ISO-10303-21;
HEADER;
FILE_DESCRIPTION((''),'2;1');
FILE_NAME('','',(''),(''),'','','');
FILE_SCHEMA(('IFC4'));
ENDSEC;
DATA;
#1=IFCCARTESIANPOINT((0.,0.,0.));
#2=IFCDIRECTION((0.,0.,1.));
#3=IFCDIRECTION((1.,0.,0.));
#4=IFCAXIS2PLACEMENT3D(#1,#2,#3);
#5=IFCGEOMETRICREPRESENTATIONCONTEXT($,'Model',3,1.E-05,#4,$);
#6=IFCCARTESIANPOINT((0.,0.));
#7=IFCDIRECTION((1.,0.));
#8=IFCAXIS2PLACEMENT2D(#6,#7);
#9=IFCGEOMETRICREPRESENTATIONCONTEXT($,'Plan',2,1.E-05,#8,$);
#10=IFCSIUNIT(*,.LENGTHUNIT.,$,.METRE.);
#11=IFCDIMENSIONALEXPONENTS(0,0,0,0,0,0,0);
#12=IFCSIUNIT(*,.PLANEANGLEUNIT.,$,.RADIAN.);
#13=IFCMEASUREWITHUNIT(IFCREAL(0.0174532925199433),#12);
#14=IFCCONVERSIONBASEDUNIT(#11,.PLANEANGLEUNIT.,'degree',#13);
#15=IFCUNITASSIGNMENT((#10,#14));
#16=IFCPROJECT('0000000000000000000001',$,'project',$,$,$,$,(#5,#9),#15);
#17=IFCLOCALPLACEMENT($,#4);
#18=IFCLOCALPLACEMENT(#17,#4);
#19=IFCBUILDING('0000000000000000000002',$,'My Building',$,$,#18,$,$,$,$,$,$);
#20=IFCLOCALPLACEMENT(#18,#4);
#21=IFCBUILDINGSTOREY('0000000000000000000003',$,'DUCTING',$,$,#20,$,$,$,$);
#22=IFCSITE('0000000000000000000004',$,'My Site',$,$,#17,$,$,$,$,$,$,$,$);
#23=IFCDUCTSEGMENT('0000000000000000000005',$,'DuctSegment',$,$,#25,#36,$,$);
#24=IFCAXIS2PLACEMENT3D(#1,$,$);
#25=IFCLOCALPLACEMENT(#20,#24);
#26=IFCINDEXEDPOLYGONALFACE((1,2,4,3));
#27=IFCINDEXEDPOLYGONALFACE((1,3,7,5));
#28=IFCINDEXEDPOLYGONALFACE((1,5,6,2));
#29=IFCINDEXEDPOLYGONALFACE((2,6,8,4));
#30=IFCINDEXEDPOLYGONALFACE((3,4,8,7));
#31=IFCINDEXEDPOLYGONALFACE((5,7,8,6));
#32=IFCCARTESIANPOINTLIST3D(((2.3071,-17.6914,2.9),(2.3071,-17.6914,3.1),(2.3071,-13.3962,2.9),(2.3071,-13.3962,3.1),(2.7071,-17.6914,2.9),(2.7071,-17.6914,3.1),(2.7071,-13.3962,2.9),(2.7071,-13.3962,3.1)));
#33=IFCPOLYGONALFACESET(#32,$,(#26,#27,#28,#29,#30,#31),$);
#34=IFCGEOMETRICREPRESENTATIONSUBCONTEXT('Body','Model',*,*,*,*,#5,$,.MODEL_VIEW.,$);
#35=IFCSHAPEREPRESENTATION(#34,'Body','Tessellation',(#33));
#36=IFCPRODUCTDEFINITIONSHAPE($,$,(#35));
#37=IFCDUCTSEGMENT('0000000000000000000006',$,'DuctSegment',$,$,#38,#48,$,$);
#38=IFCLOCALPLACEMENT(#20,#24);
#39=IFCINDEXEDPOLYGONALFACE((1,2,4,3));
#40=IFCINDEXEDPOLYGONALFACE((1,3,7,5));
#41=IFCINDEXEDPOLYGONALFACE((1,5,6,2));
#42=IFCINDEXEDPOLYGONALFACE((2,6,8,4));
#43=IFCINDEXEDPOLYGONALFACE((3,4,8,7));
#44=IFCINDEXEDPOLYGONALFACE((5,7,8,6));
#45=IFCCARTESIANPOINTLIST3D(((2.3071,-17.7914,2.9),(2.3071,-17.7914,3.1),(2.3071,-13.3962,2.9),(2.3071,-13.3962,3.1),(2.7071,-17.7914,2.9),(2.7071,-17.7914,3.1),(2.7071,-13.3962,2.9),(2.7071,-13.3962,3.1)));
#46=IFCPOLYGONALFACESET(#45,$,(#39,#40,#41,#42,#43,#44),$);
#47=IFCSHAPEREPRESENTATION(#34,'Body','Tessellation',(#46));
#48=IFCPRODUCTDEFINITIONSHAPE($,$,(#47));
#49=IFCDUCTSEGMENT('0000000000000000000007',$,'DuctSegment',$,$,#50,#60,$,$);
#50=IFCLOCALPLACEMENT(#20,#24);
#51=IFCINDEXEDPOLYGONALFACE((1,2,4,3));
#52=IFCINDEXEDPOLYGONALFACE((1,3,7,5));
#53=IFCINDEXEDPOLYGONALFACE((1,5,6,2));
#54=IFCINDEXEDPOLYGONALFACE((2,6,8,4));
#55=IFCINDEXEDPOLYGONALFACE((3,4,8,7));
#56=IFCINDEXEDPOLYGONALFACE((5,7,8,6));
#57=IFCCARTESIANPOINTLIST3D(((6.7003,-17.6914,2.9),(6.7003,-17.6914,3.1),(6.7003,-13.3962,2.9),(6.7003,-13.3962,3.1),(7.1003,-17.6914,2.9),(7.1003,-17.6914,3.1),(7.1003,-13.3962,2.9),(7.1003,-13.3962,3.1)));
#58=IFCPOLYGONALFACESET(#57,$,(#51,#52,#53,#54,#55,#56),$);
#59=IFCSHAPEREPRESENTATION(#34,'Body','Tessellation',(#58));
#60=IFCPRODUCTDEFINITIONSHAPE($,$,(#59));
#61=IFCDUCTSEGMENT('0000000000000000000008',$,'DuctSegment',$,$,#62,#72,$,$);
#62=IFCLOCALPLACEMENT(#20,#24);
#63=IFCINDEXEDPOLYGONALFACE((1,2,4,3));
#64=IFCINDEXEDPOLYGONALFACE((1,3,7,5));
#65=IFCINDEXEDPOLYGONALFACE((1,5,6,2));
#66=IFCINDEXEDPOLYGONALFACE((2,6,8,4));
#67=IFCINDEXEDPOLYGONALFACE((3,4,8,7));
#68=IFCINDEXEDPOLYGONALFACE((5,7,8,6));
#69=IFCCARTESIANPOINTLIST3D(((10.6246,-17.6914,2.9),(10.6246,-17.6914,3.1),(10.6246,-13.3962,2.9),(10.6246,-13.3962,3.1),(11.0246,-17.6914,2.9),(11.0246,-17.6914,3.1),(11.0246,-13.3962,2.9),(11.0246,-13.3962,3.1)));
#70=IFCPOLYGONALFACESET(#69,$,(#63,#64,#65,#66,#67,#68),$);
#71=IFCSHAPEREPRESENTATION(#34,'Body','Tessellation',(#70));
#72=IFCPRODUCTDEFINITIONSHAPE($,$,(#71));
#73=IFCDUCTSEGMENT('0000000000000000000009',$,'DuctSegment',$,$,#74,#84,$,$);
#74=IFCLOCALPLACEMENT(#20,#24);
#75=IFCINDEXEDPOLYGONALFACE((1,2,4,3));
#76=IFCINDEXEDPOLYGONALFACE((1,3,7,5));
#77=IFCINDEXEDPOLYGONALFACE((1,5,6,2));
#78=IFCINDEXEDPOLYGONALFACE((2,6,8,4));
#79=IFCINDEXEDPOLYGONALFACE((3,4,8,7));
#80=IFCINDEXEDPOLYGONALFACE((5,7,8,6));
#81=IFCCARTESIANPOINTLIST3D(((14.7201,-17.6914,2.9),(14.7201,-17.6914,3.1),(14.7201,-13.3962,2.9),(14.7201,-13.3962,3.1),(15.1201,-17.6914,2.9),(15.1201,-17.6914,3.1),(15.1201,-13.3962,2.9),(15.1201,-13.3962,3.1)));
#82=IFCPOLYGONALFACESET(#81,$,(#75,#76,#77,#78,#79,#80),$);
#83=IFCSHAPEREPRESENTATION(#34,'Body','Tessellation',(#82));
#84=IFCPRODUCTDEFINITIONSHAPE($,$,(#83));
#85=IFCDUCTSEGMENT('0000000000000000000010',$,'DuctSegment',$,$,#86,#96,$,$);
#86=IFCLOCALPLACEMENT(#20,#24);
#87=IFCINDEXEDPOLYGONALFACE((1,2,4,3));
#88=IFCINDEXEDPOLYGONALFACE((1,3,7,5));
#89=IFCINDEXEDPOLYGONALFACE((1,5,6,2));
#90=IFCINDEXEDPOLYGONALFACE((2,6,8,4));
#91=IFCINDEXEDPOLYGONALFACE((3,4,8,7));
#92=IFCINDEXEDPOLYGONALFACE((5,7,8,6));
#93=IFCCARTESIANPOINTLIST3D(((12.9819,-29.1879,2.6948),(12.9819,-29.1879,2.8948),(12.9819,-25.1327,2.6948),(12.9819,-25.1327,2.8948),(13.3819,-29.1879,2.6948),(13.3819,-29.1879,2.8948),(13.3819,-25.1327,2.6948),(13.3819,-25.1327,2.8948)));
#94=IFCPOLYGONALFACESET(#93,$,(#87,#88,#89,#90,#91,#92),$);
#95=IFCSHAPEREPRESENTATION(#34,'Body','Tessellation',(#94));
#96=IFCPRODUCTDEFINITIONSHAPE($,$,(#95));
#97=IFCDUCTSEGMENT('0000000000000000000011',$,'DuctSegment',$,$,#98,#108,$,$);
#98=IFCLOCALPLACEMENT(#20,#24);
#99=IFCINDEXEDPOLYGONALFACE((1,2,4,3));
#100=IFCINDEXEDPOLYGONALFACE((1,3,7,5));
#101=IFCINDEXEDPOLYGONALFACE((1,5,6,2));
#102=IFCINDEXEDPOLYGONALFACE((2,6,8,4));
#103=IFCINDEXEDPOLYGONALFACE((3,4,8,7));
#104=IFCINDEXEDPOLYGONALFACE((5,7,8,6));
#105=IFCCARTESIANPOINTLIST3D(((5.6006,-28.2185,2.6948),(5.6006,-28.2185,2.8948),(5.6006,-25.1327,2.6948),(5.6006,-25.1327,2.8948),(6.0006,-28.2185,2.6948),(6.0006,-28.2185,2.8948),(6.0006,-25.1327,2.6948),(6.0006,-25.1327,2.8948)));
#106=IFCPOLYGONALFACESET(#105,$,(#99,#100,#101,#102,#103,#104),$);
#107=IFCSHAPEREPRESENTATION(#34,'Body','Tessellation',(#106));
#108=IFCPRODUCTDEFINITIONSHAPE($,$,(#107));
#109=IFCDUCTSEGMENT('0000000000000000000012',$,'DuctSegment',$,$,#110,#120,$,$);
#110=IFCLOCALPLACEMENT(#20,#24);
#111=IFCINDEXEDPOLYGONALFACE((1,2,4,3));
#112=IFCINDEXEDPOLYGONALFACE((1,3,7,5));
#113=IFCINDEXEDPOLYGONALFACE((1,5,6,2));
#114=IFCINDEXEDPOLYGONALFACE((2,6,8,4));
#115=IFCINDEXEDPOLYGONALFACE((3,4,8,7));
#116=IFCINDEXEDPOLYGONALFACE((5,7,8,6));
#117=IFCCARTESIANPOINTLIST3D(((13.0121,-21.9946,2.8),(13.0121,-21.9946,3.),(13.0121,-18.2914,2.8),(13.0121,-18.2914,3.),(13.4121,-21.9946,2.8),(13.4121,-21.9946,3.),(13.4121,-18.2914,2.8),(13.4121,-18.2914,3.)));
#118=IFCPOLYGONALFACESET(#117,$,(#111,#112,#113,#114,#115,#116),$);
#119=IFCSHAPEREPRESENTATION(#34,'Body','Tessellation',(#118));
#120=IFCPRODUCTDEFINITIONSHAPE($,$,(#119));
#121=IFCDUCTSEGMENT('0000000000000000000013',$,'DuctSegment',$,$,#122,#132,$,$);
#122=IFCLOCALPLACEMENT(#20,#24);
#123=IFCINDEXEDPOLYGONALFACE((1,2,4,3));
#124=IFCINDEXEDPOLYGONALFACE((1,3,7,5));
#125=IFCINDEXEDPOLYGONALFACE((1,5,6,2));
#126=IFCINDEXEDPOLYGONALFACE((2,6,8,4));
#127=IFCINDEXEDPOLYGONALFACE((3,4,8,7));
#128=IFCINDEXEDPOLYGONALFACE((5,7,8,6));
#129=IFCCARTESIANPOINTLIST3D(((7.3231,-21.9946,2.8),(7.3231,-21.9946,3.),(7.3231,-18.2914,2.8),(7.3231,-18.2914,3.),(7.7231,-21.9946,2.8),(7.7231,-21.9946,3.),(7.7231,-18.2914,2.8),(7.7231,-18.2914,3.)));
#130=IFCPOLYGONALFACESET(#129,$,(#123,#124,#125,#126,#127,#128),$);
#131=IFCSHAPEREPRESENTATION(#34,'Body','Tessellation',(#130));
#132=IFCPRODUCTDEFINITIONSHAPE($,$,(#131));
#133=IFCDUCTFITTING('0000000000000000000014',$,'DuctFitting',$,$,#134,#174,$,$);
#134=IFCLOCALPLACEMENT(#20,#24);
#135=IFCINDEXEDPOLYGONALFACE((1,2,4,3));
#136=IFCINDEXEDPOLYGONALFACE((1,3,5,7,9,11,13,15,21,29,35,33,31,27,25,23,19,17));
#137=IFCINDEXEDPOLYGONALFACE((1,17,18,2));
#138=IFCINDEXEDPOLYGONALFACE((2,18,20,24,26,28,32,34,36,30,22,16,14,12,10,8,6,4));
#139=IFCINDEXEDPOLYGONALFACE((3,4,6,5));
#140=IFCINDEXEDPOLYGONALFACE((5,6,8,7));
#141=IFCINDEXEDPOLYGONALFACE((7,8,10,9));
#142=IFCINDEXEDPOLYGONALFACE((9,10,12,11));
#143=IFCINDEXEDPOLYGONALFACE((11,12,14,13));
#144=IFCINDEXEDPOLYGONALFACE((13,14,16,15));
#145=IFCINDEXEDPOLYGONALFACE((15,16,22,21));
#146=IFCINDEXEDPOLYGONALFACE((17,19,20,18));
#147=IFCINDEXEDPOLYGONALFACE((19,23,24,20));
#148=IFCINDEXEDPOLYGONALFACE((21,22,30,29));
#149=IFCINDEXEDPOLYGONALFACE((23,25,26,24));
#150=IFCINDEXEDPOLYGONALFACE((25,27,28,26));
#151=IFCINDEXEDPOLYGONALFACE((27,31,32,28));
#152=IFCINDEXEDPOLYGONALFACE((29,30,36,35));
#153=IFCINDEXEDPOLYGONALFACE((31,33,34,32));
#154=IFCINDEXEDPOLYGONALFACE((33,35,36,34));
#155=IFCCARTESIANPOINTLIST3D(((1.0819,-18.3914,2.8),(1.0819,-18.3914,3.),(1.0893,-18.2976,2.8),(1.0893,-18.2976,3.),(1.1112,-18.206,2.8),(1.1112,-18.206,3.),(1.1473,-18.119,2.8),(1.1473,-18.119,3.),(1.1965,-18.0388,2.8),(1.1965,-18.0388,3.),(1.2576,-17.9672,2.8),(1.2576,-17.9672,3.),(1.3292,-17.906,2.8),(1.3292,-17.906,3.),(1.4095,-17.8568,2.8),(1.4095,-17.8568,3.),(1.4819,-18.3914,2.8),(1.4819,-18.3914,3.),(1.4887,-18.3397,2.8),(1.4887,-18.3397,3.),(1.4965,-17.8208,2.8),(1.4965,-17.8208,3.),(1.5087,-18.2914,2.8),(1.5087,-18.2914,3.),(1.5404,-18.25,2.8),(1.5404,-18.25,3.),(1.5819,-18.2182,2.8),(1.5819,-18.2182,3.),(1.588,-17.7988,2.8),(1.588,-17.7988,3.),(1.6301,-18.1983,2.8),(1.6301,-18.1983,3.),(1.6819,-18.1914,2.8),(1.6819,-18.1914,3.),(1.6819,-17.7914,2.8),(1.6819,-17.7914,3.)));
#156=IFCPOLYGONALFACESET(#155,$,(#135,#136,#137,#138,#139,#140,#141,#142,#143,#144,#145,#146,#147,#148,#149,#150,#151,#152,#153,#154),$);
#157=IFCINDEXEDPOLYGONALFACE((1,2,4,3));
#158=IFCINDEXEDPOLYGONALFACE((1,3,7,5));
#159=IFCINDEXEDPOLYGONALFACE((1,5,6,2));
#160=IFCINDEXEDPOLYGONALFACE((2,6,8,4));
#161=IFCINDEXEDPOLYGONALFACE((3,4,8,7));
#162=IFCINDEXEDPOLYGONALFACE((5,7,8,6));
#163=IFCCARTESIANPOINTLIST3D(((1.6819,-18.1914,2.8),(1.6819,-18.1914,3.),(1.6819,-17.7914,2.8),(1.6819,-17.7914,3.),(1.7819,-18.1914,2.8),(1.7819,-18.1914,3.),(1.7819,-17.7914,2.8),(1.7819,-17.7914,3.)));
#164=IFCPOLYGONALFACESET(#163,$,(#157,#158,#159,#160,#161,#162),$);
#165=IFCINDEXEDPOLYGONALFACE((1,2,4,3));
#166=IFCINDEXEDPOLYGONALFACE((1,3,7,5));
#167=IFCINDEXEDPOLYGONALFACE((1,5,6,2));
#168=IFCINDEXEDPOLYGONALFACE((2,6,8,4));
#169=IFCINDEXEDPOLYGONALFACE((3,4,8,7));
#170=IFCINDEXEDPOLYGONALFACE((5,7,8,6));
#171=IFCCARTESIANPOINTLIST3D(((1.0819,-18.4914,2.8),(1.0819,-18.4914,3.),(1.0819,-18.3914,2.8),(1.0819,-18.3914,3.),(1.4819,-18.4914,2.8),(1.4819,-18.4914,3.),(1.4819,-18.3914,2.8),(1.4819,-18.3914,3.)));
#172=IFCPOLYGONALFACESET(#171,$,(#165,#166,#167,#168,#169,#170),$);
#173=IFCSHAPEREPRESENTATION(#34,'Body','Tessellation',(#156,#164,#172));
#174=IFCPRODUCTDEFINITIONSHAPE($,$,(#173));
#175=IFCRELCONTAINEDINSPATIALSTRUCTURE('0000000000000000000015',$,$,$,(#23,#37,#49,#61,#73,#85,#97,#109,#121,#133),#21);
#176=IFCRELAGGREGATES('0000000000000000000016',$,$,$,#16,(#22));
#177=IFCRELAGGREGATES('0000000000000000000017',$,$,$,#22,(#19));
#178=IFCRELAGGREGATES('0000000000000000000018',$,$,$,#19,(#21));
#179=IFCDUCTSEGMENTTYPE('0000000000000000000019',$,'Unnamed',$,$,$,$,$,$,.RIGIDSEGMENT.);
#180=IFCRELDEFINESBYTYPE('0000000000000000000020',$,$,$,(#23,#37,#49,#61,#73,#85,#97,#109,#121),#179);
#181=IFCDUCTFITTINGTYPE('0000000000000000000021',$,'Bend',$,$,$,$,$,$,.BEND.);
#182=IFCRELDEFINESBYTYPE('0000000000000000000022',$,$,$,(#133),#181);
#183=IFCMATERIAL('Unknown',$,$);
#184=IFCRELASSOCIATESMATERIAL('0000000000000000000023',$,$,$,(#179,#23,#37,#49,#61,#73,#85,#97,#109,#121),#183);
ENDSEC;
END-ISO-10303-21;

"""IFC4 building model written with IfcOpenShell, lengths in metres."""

from ifc_helpers import new_model, entity, si_unit, converted_unit, frame, origin_with_axes, origin_2d_with_axis, place, context, subcontext, project, spatial, line, arc, indexed_curve, rectangle, outline, extrude, source, transform, mapped, material, material_profile, profile_set, profile_usage, type_object, type_shapes, element, save


model = new_model("IFC4")

# Units and contexts
model_context = context("Model", 3, precision=1e-05, world=origin_with_axes())
plan_context = context("Plan", 2, precision=1e-05, world=origin_2d_with_axis())
body_context = subcontext(model_context, "Body", "Model", "MODEL_VIEW")
ifc_project = project(units=[si_unit("LENGTHUNIT", "METRE"), converted_unit("PLANEANGLEUNIT", "degree", entity("IfcReal", 0.0174532925199433), si_unit("PLANEANGLEUNIT", "RADIAN"), dimensions=[0, 0, 0, 0, 0, 0, 0])], contexts=[model_context, plan_context])

# Site, building, storey
site_placement = place(None, origin_with_axes())
site = spatial("IfcSite", under=ifc_project, at=site_placement, Name="My Site")
building_placement = place(site_placement, origin_with_axes())
building = spatial("IfcBuilding", under=site, at=building_placement, Name="My Building")
storey_placement = place(building_placement, origin_with_axes())
storey = spatial("IfcBuildingStorey", under=building, at=storey_placement, Name="DUCTING")

# Duct segments
ifc_material = material(Name="Unknown")
ifc_material_profile_1 = material_profile(ifc_material, rectangle(XDim=0.4, YDim=0.2))
ifc_profile_set_1 = profile_set([ifc_material_profile_1])
ifc_profile_usage_1 = profile_usage(ifc_profile_set_1, cardinal=5)
duct_segment_type = type_object("IfcDuctSegmentType", Name="Unnamed", PredefinedType="RIGIDSEGMENT", material=ifc_profile_set_1)
duct_segment_1_placement = place(storey_placement, frame((2.5071, -17.6914, 3.0), z_axis=(0.0, 1.0, 0.0), x_axis=(-1.0, 0.0, 0.0)))
element("IfcDuctSegment", 1, at=duct_segment_1_placement, inside=storey, type_object=duct_segment_type, material=ifc_profile_usage_1, Name="DuctSegment", context=body_context, shape_type="SweptSolid", body=[
    extrude(rectangle(XDim=0.4, YDim=0.2), origin_with_axes(), (0.0, 0.0, 1.0), 4.2953),
])
ifc_profile_usage_2 = profile_usage(ifc_profile_set_1, cardinal=5)
duct_segment_2_placement = place(storey_placement, frame((2.5071, -17.7914, 3.0), z_axis=(0.0, 1.0, 0.0), x_axis=(-1.0, 0.0, 0.0)))
element("IfcDuctSegment", 2, at=duct_segment_2_placement, inside=storey, type_object=duct_segment_type, material=ifc_profile_usage_2, Name="DuctSegment", context=body_context, shape_type="SweptSolid", body=[
    extrude(rectangle(XDim=0.4, YDim=0.2), origin_with_axes(), (0.0, 0.0, 1.0), 4.3953),
])
ifc_profile_usage_3 = profile_usage(ifc_profile_set_1, cardinal=5)
duct_segment_3_placement = place(storey_placement, frame((6.9003, -17.6914, 3.0), z_axis=(0.0, 1.0, 0.0), x_axis=(-1.0, 0.0, 0.0)))
element("IfcDuctSegment", 3, at=duct_segment_3_placement, inside=storey, type_object=duct_segment_type, material=ifc_profile_usage_3, Name="DuctSegment", context=body_context, shape_type="SweptSolid", body=[
    extrude(rectangle(XDim=0.4, YDim=0.2), origin_with_axes(), (0.0, 0.0, 1.0), 4.2953),
])
ifc_profile_usage_4 = profile_usage(ifc_profile_set_1, cardinal=5)
duct_segment_4_placement = place(storey_placement, frame((10.8246, -17.6914, 3.0), z_axis=(0.0, 1.0, 0.0), x_axis=(-1.0, 0.0, 0.0)))
element("IfcDuctSegment", 4, at=duct_segment_4_placement, inside=storey, type_object=duct_segment_type, material=ifc_profile_usage_4, Name="DuctSegment", context=body_context, shape_type="SweptSolid", body=[
    extrude(rectangle(XDim=0.4, YDim=0.2), origin_with_axes(), (0.0, 0.0, 1.0), 4.2953),
])
ifc_profile_usage_5 = profile_usage(ifc_profile_set_1, cardinal=5)
duct_segment_5_placement = place(storey_placement, frame((14.9201, -17.6914, 3.0), z_axis=(0.0, 1.0, 0.0), x_axis=(-1.0, 0.0, 0.0)))
element("IfcDuctSegment", 5, at=duct_segment_5_placement, inside=storey, type_object=duct_segment_type, material=ifc_profile_usage_5, Name="DuctSegment", context=body_context, shape_type="SweptSolid", body=[
    extrude(rectangle(XDim=0.4, YDim=0.2), origin_with_axes(), (0.0, 0.0, 1.0), 4.2953),
])
ifc_profile_usage_6 = profile_usage(ifc_profile_set_1, cardinal=5)
duct_segment_6_placement = place(storey_placement, frame((13.1819, -25.1327, 2.7948), z_axis=(0.0, -1.0, 0.0), x_axis=(1.0, 0.0, 0.0)))
element("IfcDuctSegment", 6, at=duct_segment_6_placement, inside=storey, type_object=duct_segment_type, material=ifc_profile_usage_6, Name="DuctSegment", context=body_context, shape_type="SweptSolid", body=[
    extrude(rectangle(XDim=0.4, YDim=0.2), origin_with_axes(), (0.0, 0.0, 1.0), 4.0552),
])
ifc_profile_usage_7 = profile_usage(ifc_profile_set_1, cardinal=5)
duct_segment_7_placement = place(storey_placement, frame((5.8006, -25.1327, 2.7948), z_axis=(0.0, -1.0, 0.0), x_axis=(1.0, 0.0, 0.0)))
element("IfcDuctSegment", 7, at=duct_segment_7_placement, inside=storey, type_object=duct_segment_type, material=ifc_profile_usage_7, Name="DuctSegment", context=body_context, shape_type="SweptSolid", body=[
    extrude(rectangle(XDim=0.4, YDim=0.2), origin_with_axes(), (0.0, 0.0, 1.0), 3.0858),
])
ifc_profile_usage_8 = profile_usage(ifc_profile_set_1, cardinal=5)
duct_segment_8_placement = place(storey_placement, frame((13.2121, -18.2914, 2.9), z_axis=(0.0, -1.0, 0.0), x_axis=(1.0, 0.0, 0.0)))
element("IfcDuctSegment", 8, at=duct_segment_8_placement, inside=storey, type_object=duct_segment_type, material=ifc_profile_usage_8, Name="DuctSegment", context=body_context, shape_type="SweptSolid", body=[
    extrude(rectangle(XDim=0.4, YDim=0.2), origin_with_axes(), (0.0, 0.0, 1.0), 3.7032),
])
ifc_profile_usage_9 = profile_usage(ifc_profile_set_1, cardinal=5)
duct_segment_9_placement = place(storey_placement, frame((7.5231, -18.2914, 2.9), z_axis=(0.0, -1.0, 0.0), x_axis=(1.0, 0.0, 0.0)))
element("IfcDuctSegment", 9, at=duct_segment_9_placement, inside=storey, type_object=duct_segment_type, material=ifc_profile_usage_9, Name="DuctSegment", context=body_context, shape_type="SweptSolid", body=[
    extrude(rectangle(XDim=0.4, YDim=0.2), origin_with_axes(), (0.0, 0.0, 1.0), 3.7032),
])

# Duct fitting
duct_fitting_type_1 = type_object("IfcDuctFittingType", Name="Bend", PredefinedType="BEND")
shared_shape = source(origin_with_axes(), body_context, "Body", "SweptSolid", [
    extrude(outline(indexed_curve([(-0.2, 0.0), (-0.2586, -0.1414), (-0.4, -0.2), (-0.4, -0.6), (0.0243, -0.4243), (0.2, 0.0)], segments=[arc(1, 2, 3), line(3, 4), arc(4, 5, 6), line(6, 1)])), frame((0.0, -0.1, -0.1), z_axis=(0.0, -1.0, 0.0), x_axis=(1.0, 0.0, 0.0)), (0.0, 0.0, -1.0), 0.2),
    extrude(rectangle(XDim=0.4, YDim=0.2), origin_with_axes(), (0.0, 0.0, -1.0), 0.1),
    extrude(rectangle(XDim=0.4, YDim=0.2), frame((-0.4, 0.0, -0.5), z_axis=(-1.0, 0.0, 0.0), x_axis=(0.0, 0.0, -1.0)), (0.0, 0.0, 1.0), 0.1),
])
type_shapes(duct_fitting_type_1, [shared_shape])
for number, where, z_axis, x_axis, name in (
    (10, (1.7819, -17.9914, 2.9), (1.0, 0.0, 0.0), (0.0, 1.0, 0.0), "DuctFitting"),
):
    element("IfcDuctFitting", number, at=place(storey_placement, frame(where, z_axis=z_axis, x_axis=x_axis)), inside=storey, type_object=duct_fitting_type_1, Name=name, context=body_context, shape_type="MappedRepresentation", body=[
        mapped(shared_shape, transform((0.0, 0.0, 0.0), x_axis=(1.0, 0.0, 0.0), y_axis=(0.0, 1.0, 0.0), z_axis=(0.0, 0.0, 1.0), scale=1.0)),
    ])

save(model, "model.ifc")
